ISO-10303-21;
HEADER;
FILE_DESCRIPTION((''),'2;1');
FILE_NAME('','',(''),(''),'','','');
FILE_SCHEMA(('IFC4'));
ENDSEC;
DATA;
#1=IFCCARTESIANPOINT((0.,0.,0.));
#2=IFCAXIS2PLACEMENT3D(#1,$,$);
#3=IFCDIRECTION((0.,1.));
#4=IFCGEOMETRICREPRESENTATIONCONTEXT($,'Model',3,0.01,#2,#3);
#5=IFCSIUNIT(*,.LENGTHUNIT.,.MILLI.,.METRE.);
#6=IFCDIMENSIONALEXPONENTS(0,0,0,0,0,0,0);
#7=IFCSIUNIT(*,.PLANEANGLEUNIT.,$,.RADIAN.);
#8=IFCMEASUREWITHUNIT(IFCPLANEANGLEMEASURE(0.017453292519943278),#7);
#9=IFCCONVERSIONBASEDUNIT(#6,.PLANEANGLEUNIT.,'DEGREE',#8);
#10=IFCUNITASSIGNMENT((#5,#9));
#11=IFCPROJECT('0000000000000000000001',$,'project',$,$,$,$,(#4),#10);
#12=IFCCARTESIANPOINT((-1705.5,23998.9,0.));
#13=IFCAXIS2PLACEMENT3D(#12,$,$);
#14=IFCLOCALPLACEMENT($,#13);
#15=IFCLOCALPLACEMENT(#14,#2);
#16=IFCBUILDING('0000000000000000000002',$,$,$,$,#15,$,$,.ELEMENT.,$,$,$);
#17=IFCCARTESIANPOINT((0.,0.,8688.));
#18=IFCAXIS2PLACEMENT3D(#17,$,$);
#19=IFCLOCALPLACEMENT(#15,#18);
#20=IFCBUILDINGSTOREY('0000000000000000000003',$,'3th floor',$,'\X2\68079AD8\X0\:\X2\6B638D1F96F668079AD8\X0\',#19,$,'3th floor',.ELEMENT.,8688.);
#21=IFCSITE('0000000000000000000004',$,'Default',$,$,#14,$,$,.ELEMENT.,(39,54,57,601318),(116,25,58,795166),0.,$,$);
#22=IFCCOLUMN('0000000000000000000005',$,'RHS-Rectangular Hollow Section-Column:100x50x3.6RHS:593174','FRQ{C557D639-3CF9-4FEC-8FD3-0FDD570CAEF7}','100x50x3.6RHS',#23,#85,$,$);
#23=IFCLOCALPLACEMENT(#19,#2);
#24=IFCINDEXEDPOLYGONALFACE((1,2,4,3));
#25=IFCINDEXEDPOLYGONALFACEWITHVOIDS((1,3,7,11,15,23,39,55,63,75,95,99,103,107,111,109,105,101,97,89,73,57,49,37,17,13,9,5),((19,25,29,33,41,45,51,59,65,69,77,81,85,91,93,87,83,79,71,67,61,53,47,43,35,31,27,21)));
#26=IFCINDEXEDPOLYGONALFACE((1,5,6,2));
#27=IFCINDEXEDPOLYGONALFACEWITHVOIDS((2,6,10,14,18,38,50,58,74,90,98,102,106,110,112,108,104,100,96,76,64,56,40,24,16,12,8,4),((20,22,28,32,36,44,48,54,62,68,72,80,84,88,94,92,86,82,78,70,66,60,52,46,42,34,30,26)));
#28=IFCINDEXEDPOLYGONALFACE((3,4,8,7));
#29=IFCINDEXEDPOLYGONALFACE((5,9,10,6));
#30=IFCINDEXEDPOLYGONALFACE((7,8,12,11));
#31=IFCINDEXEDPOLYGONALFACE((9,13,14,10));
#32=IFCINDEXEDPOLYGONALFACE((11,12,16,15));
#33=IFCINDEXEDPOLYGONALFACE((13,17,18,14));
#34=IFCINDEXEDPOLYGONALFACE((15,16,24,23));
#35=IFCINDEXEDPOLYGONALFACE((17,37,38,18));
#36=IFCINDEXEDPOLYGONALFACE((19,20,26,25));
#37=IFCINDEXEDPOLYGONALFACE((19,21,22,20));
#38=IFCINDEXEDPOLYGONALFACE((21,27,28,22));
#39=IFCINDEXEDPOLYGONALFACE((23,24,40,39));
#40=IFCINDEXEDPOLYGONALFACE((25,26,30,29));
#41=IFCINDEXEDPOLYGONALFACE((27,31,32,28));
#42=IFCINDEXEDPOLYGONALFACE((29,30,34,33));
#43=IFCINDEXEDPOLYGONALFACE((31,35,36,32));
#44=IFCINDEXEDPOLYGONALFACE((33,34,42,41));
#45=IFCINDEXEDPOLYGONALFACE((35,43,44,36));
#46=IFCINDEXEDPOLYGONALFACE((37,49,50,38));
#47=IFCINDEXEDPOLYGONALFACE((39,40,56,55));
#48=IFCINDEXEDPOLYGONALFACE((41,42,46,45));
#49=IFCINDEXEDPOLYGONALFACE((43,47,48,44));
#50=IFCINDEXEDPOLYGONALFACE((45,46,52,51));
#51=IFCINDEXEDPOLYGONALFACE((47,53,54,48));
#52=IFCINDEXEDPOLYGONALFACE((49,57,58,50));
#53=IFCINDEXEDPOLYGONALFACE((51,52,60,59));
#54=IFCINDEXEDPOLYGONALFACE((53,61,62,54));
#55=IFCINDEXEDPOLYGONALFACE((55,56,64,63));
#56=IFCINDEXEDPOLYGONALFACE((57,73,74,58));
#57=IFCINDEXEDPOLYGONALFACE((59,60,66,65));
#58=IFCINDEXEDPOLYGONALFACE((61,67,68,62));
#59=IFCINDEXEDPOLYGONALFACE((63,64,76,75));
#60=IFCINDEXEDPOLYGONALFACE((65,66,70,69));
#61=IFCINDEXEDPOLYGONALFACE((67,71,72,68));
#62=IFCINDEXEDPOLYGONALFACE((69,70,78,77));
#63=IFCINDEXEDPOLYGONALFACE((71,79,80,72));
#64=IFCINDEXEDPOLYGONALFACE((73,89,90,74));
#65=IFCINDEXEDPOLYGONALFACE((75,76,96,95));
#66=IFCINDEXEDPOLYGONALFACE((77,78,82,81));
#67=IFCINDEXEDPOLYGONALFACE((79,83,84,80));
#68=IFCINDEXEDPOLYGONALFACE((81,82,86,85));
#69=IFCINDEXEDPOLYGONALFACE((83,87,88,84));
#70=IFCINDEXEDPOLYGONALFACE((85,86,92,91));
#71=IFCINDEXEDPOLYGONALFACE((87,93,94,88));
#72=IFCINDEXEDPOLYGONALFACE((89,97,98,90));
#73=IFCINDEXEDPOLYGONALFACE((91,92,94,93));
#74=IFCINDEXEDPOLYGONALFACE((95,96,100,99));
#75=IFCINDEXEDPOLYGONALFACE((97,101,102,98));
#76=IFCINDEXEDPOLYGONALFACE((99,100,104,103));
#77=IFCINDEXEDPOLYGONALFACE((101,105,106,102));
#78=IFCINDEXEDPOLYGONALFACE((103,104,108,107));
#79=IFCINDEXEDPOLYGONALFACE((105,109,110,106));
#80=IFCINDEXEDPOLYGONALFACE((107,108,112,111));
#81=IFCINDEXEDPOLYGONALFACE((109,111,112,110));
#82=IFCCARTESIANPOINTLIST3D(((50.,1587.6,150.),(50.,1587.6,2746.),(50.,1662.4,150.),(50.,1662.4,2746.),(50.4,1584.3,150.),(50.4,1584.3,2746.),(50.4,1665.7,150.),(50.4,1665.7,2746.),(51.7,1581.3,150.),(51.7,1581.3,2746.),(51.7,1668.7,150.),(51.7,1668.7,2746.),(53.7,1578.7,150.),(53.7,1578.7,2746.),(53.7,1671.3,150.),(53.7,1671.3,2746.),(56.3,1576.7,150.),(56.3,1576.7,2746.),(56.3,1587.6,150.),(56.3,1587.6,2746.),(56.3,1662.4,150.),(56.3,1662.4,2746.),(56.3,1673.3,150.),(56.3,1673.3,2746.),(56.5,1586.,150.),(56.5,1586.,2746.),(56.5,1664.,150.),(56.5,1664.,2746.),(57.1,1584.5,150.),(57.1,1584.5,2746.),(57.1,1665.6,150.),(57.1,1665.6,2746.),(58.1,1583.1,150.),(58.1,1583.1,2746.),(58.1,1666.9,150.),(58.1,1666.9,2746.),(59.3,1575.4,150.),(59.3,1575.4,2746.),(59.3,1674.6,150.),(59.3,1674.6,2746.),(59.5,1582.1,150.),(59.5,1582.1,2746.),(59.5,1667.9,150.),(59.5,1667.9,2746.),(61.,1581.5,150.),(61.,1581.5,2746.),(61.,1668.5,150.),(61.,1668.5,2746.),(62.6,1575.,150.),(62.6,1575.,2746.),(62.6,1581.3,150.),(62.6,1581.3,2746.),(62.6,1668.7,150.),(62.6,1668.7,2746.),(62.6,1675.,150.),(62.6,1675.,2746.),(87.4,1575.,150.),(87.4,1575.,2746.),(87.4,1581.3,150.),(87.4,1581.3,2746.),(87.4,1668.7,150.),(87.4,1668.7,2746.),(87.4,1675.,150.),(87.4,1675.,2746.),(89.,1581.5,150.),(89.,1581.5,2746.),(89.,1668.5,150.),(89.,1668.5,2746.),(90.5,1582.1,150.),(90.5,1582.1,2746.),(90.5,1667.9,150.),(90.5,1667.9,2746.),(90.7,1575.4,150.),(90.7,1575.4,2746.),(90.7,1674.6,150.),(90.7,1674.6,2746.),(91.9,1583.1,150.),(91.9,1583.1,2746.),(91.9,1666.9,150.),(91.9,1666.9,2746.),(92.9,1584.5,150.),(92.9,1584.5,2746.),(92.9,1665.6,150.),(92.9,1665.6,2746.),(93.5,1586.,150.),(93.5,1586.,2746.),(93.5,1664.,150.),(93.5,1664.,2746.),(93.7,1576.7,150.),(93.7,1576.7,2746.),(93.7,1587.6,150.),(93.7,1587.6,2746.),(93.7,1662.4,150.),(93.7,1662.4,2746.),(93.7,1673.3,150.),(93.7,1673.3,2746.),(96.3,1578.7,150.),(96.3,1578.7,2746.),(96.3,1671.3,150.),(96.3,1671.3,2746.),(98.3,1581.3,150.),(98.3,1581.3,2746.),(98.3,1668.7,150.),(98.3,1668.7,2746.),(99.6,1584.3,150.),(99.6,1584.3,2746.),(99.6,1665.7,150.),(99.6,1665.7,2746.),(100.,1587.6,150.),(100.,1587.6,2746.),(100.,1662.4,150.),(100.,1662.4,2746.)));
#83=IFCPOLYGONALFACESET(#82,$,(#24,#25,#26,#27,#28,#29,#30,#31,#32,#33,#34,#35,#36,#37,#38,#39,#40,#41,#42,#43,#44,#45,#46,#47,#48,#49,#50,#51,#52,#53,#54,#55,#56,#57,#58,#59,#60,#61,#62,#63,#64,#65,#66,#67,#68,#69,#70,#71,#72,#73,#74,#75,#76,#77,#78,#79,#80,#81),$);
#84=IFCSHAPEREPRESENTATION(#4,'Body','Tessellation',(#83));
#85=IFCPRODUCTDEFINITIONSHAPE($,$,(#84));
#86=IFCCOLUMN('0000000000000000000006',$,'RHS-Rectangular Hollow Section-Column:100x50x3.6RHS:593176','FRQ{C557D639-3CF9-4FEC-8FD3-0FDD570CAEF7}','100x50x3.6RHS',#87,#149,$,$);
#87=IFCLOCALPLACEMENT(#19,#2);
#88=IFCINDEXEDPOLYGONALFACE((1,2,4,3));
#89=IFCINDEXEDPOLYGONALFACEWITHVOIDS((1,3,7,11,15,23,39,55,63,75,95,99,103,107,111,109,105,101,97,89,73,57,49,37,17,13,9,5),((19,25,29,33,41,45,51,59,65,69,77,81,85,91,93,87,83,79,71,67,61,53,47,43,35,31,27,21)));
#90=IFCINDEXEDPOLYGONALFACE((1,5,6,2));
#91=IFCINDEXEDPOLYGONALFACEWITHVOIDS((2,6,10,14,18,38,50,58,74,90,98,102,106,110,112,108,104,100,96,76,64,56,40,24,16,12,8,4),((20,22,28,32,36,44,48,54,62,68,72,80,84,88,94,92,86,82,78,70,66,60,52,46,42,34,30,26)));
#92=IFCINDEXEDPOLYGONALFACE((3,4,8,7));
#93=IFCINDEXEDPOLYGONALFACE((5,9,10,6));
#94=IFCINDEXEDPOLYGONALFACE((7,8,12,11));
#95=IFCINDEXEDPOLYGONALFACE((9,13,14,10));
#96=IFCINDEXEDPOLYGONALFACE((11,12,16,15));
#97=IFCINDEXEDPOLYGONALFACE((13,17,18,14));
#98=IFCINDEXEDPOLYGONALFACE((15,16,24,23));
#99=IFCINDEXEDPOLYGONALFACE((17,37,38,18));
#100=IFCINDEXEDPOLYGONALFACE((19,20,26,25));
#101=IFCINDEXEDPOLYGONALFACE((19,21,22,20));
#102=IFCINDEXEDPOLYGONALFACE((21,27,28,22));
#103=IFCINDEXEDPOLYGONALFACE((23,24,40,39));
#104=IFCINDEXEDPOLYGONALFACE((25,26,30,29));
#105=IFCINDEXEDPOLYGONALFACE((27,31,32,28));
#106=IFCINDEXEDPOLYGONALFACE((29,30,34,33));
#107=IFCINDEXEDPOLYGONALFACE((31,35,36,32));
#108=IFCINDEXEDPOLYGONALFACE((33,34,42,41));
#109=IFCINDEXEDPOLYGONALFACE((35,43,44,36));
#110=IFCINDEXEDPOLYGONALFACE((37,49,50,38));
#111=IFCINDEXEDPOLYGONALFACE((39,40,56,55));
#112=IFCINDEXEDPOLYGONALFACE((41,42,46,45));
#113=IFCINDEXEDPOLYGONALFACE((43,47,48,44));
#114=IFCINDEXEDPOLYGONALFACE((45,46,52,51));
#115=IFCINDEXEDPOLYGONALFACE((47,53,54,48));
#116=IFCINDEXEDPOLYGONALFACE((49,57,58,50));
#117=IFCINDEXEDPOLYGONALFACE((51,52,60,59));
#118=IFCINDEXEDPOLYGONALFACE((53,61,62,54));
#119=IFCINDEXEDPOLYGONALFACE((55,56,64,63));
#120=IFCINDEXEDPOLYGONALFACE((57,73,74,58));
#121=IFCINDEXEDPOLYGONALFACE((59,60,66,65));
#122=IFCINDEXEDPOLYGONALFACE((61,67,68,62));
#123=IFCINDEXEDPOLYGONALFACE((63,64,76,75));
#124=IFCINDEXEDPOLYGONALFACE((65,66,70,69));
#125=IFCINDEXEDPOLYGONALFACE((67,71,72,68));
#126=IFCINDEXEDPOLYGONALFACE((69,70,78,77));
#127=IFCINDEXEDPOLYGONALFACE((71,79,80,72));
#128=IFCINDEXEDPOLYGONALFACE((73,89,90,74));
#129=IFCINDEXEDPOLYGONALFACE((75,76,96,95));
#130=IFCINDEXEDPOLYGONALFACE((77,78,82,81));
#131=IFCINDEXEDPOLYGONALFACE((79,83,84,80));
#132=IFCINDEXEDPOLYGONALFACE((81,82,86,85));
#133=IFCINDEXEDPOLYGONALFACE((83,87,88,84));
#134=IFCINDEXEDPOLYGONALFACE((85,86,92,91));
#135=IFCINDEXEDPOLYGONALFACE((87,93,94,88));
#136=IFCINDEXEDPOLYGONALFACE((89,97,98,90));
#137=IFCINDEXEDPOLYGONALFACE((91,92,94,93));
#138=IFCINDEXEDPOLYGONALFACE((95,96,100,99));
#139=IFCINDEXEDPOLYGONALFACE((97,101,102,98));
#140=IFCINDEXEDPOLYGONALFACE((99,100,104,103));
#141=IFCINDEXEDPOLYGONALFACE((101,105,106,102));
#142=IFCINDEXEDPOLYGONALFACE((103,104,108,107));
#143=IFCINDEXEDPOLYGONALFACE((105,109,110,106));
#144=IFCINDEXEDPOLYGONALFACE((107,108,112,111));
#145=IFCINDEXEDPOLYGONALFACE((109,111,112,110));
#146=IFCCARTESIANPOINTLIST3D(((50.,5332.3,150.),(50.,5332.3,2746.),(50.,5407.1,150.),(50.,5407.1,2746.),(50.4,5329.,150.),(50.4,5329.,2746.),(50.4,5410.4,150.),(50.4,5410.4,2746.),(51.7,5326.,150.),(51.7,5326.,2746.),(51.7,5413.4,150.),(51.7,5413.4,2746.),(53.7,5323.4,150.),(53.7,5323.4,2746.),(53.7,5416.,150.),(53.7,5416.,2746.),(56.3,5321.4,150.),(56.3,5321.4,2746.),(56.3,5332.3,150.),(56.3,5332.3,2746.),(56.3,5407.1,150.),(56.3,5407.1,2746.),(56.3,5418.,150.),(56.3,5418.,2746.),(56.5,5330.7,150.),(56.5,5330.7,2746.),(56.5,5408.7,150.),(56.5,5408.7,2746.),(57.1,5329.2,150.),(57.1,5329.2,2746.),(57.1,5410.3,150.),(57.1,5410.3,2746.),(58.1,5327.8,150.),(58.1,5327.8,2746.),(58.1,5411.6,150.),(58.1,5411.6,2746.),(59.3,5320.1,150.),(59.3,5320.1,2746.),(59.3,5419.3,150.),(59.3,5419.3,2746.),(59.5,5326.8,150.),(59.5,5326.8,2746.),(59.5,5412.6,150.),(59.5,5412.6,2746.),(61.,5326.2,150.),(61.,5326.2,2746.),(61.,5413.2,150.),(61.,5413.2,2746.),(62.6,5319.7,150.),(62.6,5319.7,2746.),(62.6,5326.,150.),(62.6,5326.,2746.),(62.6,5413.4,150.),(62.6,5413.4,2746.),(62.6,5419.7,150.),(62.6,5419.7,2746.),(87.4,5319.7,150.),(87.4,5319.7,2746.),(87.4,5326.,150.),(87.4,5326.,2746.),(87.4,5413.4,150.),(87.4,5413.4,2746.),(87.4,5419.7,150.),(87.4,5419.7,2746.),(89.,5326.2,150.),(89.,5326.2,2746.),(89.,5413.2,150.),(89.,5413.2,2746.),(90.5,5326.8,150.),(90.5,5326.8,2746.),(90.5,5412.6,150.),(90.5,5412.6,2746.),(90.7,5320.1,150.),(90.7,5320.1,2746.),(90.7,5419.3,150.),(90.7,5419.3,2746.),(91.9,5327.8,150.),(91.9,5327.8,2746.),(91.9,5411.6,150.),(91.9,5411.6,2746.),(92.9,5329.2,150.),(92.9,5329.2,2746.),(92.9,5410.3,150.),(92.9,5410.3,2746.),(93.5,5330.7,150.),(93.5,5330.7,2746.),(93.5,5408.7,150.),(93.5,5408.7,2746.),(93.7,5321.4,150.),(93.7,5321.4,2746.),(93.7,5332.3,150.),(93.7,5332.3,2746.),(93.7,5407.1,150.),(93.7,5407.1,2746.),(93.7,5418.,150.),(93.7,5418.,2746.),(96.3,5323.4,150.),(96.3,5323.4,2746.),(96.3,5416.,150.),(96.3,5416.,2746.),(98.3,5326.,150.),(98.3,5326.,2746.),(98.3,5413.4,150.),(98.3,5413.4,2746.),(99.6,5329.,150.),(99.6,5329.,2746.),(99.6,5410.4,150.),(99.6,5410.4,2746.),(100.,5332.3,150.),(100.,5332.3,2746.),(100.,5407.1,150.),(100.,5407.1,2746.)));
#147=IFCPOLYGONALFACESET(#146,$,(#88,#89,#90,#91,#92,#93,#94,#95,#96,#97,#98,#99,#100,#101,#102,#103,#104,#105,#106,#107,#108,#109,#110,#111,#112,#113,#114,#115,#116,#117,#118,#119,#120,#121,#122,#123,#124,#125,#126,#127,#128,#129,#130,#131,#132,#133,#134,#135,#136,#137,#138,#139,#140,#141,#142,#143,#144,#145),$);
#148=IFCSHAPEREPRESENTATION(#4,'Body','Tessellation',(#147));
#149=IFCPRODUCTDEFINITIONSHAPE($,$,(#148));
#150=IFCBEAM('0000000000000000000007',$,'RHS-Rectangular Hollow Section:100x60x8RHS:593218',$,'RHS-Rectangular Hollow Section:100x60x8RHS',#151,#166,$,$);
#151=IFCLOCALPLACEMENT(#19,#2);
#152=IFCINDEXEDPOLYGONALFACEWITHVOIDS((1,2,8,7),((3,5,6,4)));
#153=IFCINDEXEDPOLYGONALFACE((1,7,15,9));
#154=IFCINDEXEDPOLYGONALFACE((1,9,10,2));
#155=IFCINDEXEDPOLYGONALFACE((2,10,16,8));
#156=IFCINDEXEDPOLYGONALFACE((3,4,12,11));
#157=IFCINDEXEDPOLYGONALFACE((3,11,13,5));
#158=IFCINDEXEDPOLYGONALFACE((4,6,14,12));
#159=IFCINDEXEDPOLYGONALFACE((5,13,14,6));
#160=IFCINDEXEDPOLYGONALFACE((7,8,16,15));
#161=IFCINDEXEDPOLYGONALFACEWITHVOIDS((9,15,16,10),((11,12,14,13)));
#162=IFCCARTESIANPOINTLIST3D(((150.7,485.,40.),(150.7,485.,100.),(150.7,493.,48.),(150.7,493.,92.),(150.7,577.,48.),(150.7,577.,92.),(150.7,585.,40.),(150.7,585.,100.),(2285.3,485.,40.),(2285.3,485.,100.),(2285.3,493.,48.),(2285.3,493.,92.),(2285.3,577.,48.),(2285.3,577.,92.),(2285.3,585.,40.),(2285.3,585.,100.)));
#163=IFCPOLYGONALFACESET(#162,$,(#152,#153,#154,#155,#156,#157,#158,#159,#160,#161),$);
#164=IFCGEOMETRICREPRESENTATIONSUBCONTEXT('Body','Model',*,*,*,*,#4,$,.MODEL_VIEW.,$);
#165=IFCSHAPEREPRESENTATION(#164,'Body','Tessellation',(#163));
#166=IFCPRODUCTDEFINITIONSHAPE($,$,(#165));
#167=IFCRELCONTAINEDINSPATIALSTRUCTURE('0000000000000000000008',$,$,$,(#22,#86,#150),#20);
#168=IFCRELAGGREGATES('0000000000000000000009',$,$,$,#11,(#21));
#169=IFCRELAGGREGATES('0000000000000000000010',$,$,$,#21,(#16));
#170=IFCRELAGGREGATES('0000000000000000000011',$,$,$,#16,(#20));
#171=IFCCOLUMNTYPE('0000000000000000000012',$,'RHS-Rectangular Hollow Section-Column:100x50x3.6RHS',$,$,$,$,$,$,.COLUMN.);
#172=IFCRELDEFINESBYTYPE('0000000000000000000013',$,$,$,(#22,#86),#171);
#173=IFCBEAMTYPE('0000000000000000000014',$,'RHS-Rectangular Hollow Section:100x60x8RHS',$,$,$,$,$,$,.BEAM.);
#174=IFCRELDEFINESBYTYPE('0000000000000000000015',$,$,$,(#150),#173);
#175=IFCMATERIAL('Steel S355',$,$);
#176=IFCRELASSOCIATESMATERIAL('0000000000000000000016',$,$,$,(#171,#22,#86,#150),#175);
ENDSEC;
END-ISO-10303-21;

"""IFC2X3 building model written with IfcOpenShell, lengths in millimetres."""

from ifc_helpers import new_model, entity, si_unit, converted_unit, point, direction, frame, frame_2d, origin, origin_2d, place, context, subcontext, project, spatial, circle_curve, line_curve, trimmed, segment, composite_curve, rectangle, hollow_rectangle, outline, extrude, boolean, clip, halfspace, material, type_object, element, save


model = new_model("IFC2X3")

# Units and contexts
model_context = context("Model", 3, precision=0.01, world=origin(), true_north=direction((0.0, 1.0)))
body_context = subcontext(model_context, "Body", "Model", "MODEL_VIEW")
ifc_project = project(units=[si_unit("LENGTHUNIT", "METRE", prefix="MILLI"), converted_unit("PLANEANGLEUNIT", "DEGREE", entity("IfcPlaneAngleMeasure", 0.017453292519943278), si_unit("PLANEANGLEUNIT", "RADIAN"), dimensions=[0, 0, 0, 0, 0, 0, 0])], contexts=[model_context])

# Site, building, storey
site_placement = place(None, frame((-1705.5, 23998.9, 0.0)))
site = spatial("IfcSite", under=ifc_project, at=site_placement, Name="Default", CompositionType="ELEMENT", RefLatitude=(39, 54, 57, 601318), RefLongitude=(116, 25, 58, 795166), RefElevation=0.0)
building_placement = place(site_placement, origin())
building = spatial("IfcBuilding", under=site, at=building_placement, CompositionType="ELEMENT")
storey_placement = place(building_placement, frame((0.0, 0.0, 8688.0)))
storey = spatial("IfcBuildingStorey", under=building, at=storey_placement, Name="3th floor", ObjectType="标高:正负零标高", LongName="3th floor", CompositionType="ELEMENT", Elevation=8688.0)

# Shared definitions
ifc_material_1 = material(Name="Steel S355")

# Columns, openings
column_type_1 = type_object("IfcColumnType", Name="RHS-Rectangular Hollow Section-Column:100x50x3.6RHS", PredefinedType="COLUMN", material=ifc_material_1)
column_1_placement = place(storey_placement, frame((75.0, 1625.0, 2876.9)))
column_1 = element("IfcColumn", 1, at=column_1_placement, inside=storey, type_object=column_type_1, material=ifc_material_1, Name="RHS-Rectangular Hollow Section-Column:100x50x3.6RHS:593174", Description="FRQ{C557D639-3CF9-4FEC-8FD3-0FDD570CAEF7}", ObjectType="100x50x3.6RHS", context=model_context, shape_type="Clipping", body=[
    clip(clip(extrude(hollow_rectangle(XDim=50.0, YDim=100.0, WallThickness=6.3, InnerFilletRadius=6.3, OuterFilletRadius=12.6, at=origin_2d()), origin(), (0.0, 0.0, -1.0), 2782.8), halfspace(frame((-75.0, -1625.0, -2726.9), z_axis=(0.0, 0.0, 1.0), x_axis=(1.0, 0.0, 0.0)), True)), halfspace(frame((-75.0, -1625.0, -55.9), z_axis=(0.0, 0.0, -1.0), x_axis=(-1.0, 0.0, 0.0)), True)),
])
opening_1_placement = place(column_1_placement, frame((0.0, -150.1, -130.9), z_axis=(0.0, 1.0, 0.0), x_axis=(-1.0, 0.0, 0.0)))
element("IfcOpeningElement", 2, at=opening_1_placement, cuts=column_1, ObjectType="Opening", context=model_context, shape_type="SweptSolid", body=[
    extrude(outline(composite_curve([segment(trimmed(circle_curve(frame_2d((43.0, 32.0), x_axis=(1.0, 0.0)), 32.0), [point((43.0, 0.0))], [point((75.0, 32.0))], True, "CARTESIAN"), True, "CONTINUOUS"), segment(trimmed(line_curve((75.0, 32.0), (0.0, 1.0), 86.0), [point((75.0, 32.0))], [point((75.0, 118.0))], True, "CARTESIAN"), True, "CONTINUOUS"), segment(trimmed(circle_curve(frame_2d((43.0, 118.0), x_axis=(1.0, 0.0)), 32.0), [point((75.0, 118.0))], [point((43.0, 150.0))], True, "CARTESIAN"), True, "CONTINUOUS"), segment(trimmed(line_curve((43.0, 150.0), (-1.0, 0.0), 86.0), [point((43.0, 150.0))], [point((-43.0, 150.0))], True, "CARTESIAN"), True, "CONTINUOUS"), segment(trimmed(circle_curve(frame_2d((-43.0, 118.0), x_axis=(1.0, 0.0)), 32.0), [point((-43.0, 150.0))], [point((-75.0, 118.0))], True, "CARTESIAN"), True, "CONTINUOUS"), segment(trimmed(line_curve((-75.0, 118.0), (0.0, -1.0), 86.0), [point((-75.0, 118.0))], [point((-75.0, 32.0))], True, "CARTESIAN"), True, "CONTINUOUS"), segment(trimmed(circle_curve(frame_2d((-43.0, 32.0), x_axis=(1.0, 0.0)), 32.0), [point((-75.0, 32.0))], [point((-43.0, 0.0))], True, "CARTESIAN"), True, "CONTINUOUS"), segment(trimmed(line_curve((-43.0, 0.0), (1.0, 0.0), 86.0), [point((-43.0, 0.0))], [point((43.0, 0.0))], True, "CARTESIAN"), True, "CONTINUOUS")], self_intersect="UNKNOWN")), origin(), (0.0, 0.0, 1.0), 300.2),
])
column_2_placement = place(storey_placement, frame((75.0, 5369.7, 2876.9)))
column_2 = element("IfcColumn", 3, at=column_2_placement, inside=storey, type_object=column_type_1, material=ifc_material_1, Name="RHS-Rectangular Hollow Section-Column:100x50x3.6RHS:593176", Description="FRQ{C557D639-3CF9-4FEC-8FD3-0FDD570CAEF7}", ObjectType="100x50x3.6RHS", context=model_context, shape_type="Clipping", body=[
    clip(clip(extrude(hollow_rectangle(XDim=50.0, YDim=100.0, WallThickness=6.3, InnerFilletRadius=6.3, OuterFilletRadius=12.6, at=origin_2d()), origin(), (0.0, 0.0, -1.0), 2782.8), halfspace(frame((-75.0, -5369.7, -55.9), z_axis=(0.0, 0.0, -1.0), x_axis=(-1.0, 0.0, 0.0)), True)), halfspace(frame((-75.0, -5369.7, -2726.9), z_axis=(0.0, 0.0, 1.0), x_axis=(1.0, 0.0, 0.0)), True)),
])
opening_2_placement = place(column_2_placement, frame((0.0, -150.1, -130.9), z_axis=(0.0, 1.0, 0.0), x_axis=(-1.0, 0.0, 0.0)))
element("IfcOpeningElement", 4, at=opening_2_placement, cuts=column_2, ObjectType="Opening", context=model_context, shape_type="SweptSolid", body=[
    extrude(outline(composite_curve([segment(trimmed(circle_curve(frame_2d((43.0, 32.0), x_axis=(1.0, 0.0)), 32.0), [point((43.0, 0.0))], [point((75.0, 32.0))], True, "CARTESIAN"), True, "CONTINUOUS"), segment(trimmed(line_curve((75.0, 32.0), (0.0, 1.0), 86.0), [point((75.0, 32.0))], [point((75.0, 118.0))], True, "CARTESIAN"), True, "CONTINUOUS"), segment(trimmed(circle_curve(frame_2d((43.0, 118.0), x_axis=(1.0, 0.0)), 32.0), [point((75.0, 118.0))], [point((43.0, 150.0))], True, "CARTESIAN"), True, "CONTINUOUS"), segment(trimmed(line_curve((43.0, 150.0), (-1.0, 0.0), 86.0), [point((43.0, 150.0))], [point((-43.0, 150.0))], True, "CARTESIAN"), True, "CONTINUOUS"), segment(trimmed(circle_curve(frame_2d((-43.0, 118.0), x_axis=(1.0, 0.0)), 32.0), [point((-43.0, 150.0))], [point((-75.0, 118.0))], True, "CARTESIAN"), True, "CONTINUOUS"), segment(trimmed(line_curve((-75.0, 118.0), (0.0, -1.0), 86.0), [point((-75.0, 118.0))], [point((-75.0, 32.0))], True, "CARTESIAN"), True, "CONTINUOUS"), segment(trimmed(circle_curve(frame_2d((-43.0, 32.0), x_axis=(1.0, 0.0)), 32.0), [point((-75.0, 32.0))], [point((-43.0, 0.0))], True, "CARTESIAN"), True, "CONTINUOUS"), segment(trimmed(line_curve((-43.0, 0.0), (1.0, 0.0), 86.0), [point((-43.0, 0.0))], [point((43.0, 0.0))], True, "CARTESIAN"), True, "CONTINUOUS")], self_intersect="UNKNOWN")), origin(), (0.0, 0.0, 1.0), 300.2),
])

# Beam
beam_type_1 = type_object("IfcBeamType", Name="RHS-Rectangular Hollow Section:100x60x8RHS", PredefinedType="BEAM")
beam_1_placement = place(storey_placement, frame((150.7, 585.0, 70.0)))
element("IfcBeam", 5, at=beam_1_placement, inside=storey, type_object=beam_type_1, material=ifc_material_1, Name="RHS-Rectangular Hollow Section:100x60x8RHS:593218", ObjectType="RHS-Rectangular Hollow Section:100x60x8RHS", context=body_context, shape_type="SweptSolid", body=[
    boolean("DIFFERENCE", extrude(rectangle(XDim=60.0, YDim=100.0, at=frame_2d((0.0, 0.0), x_axis=(1.0, 0.0))), frame((0.0, -50.0, 0.0), z_axis=(1.0, 0.0, 0.0), x_axis=(0.0, 0.0, -1.0)), (0.0, 0.0, 1.0), 2134.6), extrude(rectangle(XDim=44.0, YDim=84.0, at=frame_2d((0.0, 0.0), x_axis=(0.0, 1.0))), frame((2134.6, -50.0, 0.0), z_axis=(-1.0, 0.0, 0.0), x_axis=(0.0, 1.0, 0.0)), (0.0, 0.0, 1.0), 2134.6)),
])

save(model, "model.ifc")
